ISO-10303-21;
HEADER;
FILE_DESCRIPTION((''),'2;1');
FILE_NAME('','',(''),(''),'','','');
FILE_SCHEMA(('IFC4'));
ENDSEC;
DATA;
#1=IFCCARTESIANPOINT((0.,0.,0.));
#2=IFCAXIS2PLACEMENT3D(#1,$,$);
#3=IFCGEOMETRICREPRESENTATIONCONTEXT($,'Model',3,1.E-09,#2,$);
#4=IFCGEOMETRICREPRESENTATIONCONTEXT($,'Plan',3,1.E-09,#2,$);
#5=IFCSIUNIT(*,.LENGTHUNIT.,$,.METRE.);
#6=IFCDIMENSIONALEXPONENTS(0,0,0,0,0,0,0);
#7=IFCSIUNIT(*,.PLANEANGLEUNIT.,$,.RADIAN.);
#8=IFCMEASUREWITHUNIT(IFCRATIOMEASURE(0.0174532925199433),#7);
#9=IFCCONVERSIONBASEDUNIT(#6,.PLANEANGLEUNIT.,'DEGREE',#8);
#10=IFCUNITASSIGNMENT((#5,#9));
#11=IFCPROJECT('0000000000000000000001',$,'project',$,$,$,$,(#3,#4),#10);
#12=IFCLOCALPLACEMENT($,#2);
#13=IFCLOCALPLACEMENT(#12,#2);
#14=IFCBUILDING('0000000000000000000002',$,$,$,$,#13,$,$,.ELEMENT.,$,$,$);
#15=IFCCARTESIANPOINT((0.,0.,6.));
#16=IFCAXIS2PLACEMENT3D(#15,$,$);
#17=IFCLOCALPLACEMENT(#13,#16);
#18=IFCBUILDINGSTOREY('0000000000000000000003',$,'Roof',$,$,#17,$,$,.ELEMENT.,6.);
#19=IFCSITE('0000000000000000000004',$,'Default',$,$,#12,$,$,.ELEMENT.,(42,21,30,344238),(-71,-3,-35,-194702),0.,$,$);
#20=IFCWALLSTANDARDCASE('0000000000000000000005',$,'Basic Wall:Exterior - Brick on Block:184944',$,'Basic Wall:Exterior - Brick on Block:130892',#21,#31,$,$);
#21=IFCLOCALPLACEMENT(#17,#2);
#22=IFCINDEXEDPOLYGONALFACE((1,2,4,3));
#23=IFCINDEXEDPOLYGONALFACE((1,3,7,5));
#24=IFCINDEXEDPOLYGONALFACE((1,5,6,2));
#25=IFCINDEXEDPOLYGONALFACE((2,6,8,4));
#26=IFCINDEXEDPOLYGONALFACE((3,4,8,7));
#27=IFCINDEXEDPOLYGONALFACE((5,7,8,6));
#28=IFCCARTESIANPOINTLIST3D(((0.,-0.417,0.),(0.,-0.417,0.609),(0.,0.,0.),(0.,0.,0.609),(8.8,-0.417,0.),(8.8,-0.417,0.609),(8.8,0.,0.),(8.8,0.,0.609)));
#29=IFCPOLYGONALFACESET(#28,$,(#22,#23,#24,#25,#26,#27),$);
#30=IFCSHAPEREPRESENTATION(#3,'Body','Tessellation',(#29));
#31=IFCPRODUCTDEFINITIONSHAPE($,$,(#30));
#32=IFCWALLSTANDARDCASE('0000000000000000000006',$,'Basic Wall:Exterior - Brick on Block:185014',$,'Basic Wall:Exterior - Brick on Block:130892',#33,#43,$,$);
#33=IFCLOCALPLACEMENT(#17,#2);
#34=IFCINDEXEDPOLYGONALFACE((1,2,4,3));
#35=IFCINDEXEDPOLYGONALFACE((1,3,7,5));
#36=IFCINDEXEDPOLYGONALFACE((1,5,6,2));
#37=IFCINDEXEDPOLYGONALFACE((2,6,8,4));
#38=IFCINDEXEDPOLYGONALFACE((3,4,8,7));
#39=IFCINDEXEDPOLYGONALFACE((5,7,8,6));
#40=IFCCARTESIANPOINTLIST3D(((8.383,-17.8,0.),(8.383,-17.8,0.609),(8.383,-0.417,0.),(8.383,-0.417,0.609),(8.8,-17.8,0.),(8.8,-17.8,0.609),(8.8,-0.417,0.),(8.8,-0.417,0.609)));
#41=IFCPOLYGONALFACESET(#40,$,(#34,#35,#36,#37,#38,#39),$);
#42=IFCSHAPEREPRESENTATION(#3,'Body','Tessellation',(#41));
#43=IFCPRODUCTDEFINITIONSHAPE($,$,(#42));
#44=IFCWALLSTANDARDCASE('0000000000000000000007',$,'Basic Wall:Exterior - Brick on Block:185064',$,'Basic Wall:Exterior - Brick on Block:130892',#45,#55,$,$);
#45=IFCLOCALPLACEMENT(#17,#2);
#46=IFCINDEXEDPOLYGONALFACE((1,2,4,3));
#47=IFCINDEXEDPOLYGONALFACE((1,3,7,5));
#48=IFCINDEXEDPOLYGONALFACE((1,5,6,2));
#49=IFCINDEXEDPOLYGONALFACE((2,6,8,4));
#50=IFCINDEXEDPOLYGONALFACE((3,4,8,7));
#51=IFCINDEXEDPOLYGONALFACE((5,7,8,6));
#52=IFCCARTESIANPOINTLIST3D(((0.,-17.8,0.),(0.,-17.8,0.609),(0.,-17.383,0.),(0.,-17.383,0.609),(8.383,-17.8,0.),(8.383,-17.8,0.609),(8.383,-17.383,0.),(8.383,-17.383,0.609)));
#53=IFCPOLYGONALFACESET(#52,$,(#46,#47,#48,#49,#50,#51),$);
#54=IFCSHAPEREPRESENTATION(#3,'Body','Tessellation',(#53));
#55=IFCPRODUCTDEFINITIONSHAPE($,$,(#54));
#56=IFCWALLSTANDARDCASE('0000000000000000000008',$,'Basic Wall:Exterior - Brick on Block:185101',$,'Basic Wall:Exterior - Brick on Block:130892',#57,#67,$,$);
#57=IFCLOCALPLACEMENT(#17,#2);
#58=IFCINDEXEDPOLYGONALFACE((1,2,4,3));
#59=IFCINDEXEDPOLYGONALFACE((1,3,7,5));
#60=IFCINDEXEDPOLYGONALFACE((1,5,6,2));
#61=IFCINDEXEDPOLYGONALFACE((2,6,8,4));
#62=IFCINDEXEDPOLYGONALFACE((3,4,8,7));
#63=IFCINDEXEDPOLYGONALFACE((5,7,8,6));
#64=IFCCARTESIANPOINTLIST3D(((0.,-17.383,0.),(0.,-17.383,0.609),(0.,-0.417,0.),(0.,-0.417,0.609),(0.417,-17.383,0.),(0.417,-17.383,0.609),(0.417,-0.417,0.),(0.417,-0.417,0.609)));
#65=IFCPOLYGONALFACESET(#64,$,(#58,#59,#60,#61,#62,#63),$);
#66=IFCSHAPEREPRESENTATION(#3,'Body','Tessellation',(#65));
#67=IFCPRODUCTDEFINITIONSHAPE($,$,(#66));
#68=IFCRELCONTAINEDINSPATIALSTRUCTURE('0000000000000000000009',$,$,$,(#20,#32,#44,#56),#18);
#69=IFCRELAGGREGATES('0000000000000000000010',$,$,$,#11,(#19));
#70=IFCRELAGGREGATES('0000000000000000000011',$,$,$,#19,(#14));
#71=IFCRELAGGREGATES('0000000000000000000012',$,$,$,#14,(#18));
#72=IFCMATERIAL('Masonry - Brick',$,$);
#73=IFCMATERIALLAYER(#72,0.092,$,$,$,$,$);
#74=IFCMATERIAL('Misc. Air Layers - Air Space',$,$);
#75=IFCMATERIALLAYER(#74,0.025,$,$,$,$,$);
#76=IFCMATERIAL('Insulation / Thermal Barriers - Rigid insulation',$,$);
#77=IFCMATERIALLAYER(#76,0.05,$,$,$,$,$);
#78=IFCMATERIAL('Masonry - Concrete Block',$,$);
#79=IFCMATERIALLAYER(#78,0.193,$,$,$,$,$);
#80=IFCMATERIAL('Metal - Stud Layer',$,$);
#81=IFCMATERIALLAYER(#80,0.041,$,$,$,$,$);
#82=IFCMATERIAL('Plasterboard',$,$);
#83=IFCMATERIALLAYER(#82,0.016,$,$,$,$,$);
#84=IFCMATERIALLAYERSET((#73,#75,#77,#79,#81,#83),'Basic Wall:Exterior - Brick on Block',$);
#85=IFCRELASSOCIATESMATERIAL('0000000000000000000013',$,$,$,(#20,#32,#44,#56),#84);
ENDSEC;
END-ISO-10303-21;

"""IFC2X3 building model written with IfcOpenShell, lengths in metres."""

from ifc_helpers import new_model, entity, si_unit, converted_unit, frame, frame_2d, origin, place, context, project, spatial, rectangle, extrude, material, layer, layer_set, layer_usage, element, save


model = new_model("IFC2X3")

# Units and contexts
model_context = context("Model", 3, precision=1e-09, world=origin())
plan_context = context("Plan", 3, precision=1e-09, world=origin())
ifc_project = project(units=[si_unit("LENGTHUNIT", "METRE"), converted_unit("PLANEANGLEUNIT", "DEGREE", entity("IfcRatioMeasure", 0.0174532925199433), si_unit("PLANEANGLEUNIT", "RADIAN"), dimensions=[0, 0, 0, 0, 0, 0, 0])], contexts=[model_context, plan_context])

# Site, building, storey
site_placement = place(None, origin())
site = spatial("IfcSite", under=ifc_project, at=site_placement, Name="Default", CompositionType="ELEMENT", RefLatitude=(42, 21, 30, 344238), RefLongitude=(-71, -3, -35, -194702), RefElevation=0.0)
building_placement = place(site_placement, origin())
building = spatial("IfcBuilding", under=site, at=building_placement, CompositionType="ELEMENT")
storey_placement = place(building_placement, frame((0.0, 0.0, 6.0)))
storey = spatial("IfcBuildingStorey", under=building, at=storey_placement, Name="Roof", CompositionType="ELEMENT", Elevation=6.0)

# Walls
ifc_material_1 = material(Name="Masonry - Brick")
ifc_layer_1 = layer(ifc_material_1, 0.092)
ifc_material_2 = material(Name="Misc. Air Layers - Air Space")
ifc_layer_2 = layer(ifc_material_2, 0.025)
ifc_material_3 = material(Name="Insulation / Thermal Barriers - Rigid insulation")
ifc_layer_3 = layer(ifc_material_3, 0.05)
ifc_material_4 = material(Name="Masonry - Concrete Block")
ifc_layer_4 = layer(ifc_material_4, 0.193)
ifc_material_5 = material(Name="Metal - Stud Layer")
ifc_layer_5 = layer(ifc_material_5, 0.041)
ifc_material_6 = material(Name="Plasterboard")
ifc_layer_6 = layer(ifc_material_6, 0.016)
ifc_layer_set = layer_set([ifc_layer_1, ifc_layer_2, ifc_layer_3, ifc_layer_4, ifc_layer_5, ifc_layer_6], Name="Basic Wall:Exterior - Brick on Block")
ifc_layer_usage = layer_usage(ifc_layer_set, "AXIS2", "NEGATIVE", 0.2085)
wall_1_placement = place(storey_placement, frame((0.0, -0.2085, 0.0)))
element("IfcWallStandardCase", 1, at=wall_1_placement, inside=storey, material=ifc_layer_usage, Name="Basic Wall:Exterior - Brick on Block:184944", ObjectType="Basic Wall:Exterior - Brick on Block:130892", context=model_context, shape_type="SweptSolid", body=[
    extrude(rectangle(XDim=8.8, YDim=0.417, at=frame_2d((4.4, 0.0), x_axis=(-1.0, 0.0))), origin(), (0.0, 0.0, 1.0), 0.609),
])
wall_2_placement = place(storey_placement, frame((8.5915, -0.417, 0.0), z_axis=(0.0, 0.0, 1.0), x_axis=(0.0, -1.0, 0.0)))
element("IfcWallStandardCase", 2, at=wall_2_placement, inside=storey, material=ifc_layer_usage, Name="Basic Wall:Exterior - Brick on Block:185014", ObjectType="Basic Wall:Exterior - Brick on Block:130892", context=model_context, shape_type="SweptSolid", body=[
    extrude(rectangle(XDim=17.383, YDim=0.417, at=frame_2d((8.6915, 0.0), x_axis=(-1.0, 0.0))), origin(), (0.0, 0.0, 1.0), 0.609),
])
wall_3_placement = place(storey_placement, frame((8.383, -17.5915, 0.0), z_axis=(0.0, 0.0, 1.0), x_axis=(-1.0, 0.0, 0.0)))
element("IfcWallStandardCase", 3, at=wall_3_placement, inside=storey, material=ifc_layer_usage, Name="Basic Wall:Exterior - Brick on Block:185064", ObjectType="Basic Wall:Exterior - Brick on Block:130892", context=model_context, shape_type="SweptSolid", body=[
    extrude(rectangle(XDim=8.383, YDim=0.417, at=frame_2d((4.1915, 0.0), x_axis=(-1.0, 0.0))), origin(), (0.0, 0.0, 1.0), 0.609),
])
wall_4_placement = place(storey_placement, frame((0.2085, -17.383, 0.0), z_axis=(0.0, 0.0, 1.0), x_axis=(0.0, 1.0, 0.0)))
element("IfcWallStandardCase", 4, at=wall_4_placement, inside=storey, material=ifc_layer_usage, Name="Basic Wall:Exterior - Brick on Block:185101", ObjectType="Basic Wall:Exterior - Brick on Block:130892", context=model_context, shape_type="SweptSolid", body=[
    extrude(rectangle(XDim=16.966, YDim=0.417, at=frame_2d((8.483, 0.0), x_axis=(-1.0, 0.0))), origin(), (0.0, 0.0, 1.0), 0.609),
])

save(model, "model.ifc")
